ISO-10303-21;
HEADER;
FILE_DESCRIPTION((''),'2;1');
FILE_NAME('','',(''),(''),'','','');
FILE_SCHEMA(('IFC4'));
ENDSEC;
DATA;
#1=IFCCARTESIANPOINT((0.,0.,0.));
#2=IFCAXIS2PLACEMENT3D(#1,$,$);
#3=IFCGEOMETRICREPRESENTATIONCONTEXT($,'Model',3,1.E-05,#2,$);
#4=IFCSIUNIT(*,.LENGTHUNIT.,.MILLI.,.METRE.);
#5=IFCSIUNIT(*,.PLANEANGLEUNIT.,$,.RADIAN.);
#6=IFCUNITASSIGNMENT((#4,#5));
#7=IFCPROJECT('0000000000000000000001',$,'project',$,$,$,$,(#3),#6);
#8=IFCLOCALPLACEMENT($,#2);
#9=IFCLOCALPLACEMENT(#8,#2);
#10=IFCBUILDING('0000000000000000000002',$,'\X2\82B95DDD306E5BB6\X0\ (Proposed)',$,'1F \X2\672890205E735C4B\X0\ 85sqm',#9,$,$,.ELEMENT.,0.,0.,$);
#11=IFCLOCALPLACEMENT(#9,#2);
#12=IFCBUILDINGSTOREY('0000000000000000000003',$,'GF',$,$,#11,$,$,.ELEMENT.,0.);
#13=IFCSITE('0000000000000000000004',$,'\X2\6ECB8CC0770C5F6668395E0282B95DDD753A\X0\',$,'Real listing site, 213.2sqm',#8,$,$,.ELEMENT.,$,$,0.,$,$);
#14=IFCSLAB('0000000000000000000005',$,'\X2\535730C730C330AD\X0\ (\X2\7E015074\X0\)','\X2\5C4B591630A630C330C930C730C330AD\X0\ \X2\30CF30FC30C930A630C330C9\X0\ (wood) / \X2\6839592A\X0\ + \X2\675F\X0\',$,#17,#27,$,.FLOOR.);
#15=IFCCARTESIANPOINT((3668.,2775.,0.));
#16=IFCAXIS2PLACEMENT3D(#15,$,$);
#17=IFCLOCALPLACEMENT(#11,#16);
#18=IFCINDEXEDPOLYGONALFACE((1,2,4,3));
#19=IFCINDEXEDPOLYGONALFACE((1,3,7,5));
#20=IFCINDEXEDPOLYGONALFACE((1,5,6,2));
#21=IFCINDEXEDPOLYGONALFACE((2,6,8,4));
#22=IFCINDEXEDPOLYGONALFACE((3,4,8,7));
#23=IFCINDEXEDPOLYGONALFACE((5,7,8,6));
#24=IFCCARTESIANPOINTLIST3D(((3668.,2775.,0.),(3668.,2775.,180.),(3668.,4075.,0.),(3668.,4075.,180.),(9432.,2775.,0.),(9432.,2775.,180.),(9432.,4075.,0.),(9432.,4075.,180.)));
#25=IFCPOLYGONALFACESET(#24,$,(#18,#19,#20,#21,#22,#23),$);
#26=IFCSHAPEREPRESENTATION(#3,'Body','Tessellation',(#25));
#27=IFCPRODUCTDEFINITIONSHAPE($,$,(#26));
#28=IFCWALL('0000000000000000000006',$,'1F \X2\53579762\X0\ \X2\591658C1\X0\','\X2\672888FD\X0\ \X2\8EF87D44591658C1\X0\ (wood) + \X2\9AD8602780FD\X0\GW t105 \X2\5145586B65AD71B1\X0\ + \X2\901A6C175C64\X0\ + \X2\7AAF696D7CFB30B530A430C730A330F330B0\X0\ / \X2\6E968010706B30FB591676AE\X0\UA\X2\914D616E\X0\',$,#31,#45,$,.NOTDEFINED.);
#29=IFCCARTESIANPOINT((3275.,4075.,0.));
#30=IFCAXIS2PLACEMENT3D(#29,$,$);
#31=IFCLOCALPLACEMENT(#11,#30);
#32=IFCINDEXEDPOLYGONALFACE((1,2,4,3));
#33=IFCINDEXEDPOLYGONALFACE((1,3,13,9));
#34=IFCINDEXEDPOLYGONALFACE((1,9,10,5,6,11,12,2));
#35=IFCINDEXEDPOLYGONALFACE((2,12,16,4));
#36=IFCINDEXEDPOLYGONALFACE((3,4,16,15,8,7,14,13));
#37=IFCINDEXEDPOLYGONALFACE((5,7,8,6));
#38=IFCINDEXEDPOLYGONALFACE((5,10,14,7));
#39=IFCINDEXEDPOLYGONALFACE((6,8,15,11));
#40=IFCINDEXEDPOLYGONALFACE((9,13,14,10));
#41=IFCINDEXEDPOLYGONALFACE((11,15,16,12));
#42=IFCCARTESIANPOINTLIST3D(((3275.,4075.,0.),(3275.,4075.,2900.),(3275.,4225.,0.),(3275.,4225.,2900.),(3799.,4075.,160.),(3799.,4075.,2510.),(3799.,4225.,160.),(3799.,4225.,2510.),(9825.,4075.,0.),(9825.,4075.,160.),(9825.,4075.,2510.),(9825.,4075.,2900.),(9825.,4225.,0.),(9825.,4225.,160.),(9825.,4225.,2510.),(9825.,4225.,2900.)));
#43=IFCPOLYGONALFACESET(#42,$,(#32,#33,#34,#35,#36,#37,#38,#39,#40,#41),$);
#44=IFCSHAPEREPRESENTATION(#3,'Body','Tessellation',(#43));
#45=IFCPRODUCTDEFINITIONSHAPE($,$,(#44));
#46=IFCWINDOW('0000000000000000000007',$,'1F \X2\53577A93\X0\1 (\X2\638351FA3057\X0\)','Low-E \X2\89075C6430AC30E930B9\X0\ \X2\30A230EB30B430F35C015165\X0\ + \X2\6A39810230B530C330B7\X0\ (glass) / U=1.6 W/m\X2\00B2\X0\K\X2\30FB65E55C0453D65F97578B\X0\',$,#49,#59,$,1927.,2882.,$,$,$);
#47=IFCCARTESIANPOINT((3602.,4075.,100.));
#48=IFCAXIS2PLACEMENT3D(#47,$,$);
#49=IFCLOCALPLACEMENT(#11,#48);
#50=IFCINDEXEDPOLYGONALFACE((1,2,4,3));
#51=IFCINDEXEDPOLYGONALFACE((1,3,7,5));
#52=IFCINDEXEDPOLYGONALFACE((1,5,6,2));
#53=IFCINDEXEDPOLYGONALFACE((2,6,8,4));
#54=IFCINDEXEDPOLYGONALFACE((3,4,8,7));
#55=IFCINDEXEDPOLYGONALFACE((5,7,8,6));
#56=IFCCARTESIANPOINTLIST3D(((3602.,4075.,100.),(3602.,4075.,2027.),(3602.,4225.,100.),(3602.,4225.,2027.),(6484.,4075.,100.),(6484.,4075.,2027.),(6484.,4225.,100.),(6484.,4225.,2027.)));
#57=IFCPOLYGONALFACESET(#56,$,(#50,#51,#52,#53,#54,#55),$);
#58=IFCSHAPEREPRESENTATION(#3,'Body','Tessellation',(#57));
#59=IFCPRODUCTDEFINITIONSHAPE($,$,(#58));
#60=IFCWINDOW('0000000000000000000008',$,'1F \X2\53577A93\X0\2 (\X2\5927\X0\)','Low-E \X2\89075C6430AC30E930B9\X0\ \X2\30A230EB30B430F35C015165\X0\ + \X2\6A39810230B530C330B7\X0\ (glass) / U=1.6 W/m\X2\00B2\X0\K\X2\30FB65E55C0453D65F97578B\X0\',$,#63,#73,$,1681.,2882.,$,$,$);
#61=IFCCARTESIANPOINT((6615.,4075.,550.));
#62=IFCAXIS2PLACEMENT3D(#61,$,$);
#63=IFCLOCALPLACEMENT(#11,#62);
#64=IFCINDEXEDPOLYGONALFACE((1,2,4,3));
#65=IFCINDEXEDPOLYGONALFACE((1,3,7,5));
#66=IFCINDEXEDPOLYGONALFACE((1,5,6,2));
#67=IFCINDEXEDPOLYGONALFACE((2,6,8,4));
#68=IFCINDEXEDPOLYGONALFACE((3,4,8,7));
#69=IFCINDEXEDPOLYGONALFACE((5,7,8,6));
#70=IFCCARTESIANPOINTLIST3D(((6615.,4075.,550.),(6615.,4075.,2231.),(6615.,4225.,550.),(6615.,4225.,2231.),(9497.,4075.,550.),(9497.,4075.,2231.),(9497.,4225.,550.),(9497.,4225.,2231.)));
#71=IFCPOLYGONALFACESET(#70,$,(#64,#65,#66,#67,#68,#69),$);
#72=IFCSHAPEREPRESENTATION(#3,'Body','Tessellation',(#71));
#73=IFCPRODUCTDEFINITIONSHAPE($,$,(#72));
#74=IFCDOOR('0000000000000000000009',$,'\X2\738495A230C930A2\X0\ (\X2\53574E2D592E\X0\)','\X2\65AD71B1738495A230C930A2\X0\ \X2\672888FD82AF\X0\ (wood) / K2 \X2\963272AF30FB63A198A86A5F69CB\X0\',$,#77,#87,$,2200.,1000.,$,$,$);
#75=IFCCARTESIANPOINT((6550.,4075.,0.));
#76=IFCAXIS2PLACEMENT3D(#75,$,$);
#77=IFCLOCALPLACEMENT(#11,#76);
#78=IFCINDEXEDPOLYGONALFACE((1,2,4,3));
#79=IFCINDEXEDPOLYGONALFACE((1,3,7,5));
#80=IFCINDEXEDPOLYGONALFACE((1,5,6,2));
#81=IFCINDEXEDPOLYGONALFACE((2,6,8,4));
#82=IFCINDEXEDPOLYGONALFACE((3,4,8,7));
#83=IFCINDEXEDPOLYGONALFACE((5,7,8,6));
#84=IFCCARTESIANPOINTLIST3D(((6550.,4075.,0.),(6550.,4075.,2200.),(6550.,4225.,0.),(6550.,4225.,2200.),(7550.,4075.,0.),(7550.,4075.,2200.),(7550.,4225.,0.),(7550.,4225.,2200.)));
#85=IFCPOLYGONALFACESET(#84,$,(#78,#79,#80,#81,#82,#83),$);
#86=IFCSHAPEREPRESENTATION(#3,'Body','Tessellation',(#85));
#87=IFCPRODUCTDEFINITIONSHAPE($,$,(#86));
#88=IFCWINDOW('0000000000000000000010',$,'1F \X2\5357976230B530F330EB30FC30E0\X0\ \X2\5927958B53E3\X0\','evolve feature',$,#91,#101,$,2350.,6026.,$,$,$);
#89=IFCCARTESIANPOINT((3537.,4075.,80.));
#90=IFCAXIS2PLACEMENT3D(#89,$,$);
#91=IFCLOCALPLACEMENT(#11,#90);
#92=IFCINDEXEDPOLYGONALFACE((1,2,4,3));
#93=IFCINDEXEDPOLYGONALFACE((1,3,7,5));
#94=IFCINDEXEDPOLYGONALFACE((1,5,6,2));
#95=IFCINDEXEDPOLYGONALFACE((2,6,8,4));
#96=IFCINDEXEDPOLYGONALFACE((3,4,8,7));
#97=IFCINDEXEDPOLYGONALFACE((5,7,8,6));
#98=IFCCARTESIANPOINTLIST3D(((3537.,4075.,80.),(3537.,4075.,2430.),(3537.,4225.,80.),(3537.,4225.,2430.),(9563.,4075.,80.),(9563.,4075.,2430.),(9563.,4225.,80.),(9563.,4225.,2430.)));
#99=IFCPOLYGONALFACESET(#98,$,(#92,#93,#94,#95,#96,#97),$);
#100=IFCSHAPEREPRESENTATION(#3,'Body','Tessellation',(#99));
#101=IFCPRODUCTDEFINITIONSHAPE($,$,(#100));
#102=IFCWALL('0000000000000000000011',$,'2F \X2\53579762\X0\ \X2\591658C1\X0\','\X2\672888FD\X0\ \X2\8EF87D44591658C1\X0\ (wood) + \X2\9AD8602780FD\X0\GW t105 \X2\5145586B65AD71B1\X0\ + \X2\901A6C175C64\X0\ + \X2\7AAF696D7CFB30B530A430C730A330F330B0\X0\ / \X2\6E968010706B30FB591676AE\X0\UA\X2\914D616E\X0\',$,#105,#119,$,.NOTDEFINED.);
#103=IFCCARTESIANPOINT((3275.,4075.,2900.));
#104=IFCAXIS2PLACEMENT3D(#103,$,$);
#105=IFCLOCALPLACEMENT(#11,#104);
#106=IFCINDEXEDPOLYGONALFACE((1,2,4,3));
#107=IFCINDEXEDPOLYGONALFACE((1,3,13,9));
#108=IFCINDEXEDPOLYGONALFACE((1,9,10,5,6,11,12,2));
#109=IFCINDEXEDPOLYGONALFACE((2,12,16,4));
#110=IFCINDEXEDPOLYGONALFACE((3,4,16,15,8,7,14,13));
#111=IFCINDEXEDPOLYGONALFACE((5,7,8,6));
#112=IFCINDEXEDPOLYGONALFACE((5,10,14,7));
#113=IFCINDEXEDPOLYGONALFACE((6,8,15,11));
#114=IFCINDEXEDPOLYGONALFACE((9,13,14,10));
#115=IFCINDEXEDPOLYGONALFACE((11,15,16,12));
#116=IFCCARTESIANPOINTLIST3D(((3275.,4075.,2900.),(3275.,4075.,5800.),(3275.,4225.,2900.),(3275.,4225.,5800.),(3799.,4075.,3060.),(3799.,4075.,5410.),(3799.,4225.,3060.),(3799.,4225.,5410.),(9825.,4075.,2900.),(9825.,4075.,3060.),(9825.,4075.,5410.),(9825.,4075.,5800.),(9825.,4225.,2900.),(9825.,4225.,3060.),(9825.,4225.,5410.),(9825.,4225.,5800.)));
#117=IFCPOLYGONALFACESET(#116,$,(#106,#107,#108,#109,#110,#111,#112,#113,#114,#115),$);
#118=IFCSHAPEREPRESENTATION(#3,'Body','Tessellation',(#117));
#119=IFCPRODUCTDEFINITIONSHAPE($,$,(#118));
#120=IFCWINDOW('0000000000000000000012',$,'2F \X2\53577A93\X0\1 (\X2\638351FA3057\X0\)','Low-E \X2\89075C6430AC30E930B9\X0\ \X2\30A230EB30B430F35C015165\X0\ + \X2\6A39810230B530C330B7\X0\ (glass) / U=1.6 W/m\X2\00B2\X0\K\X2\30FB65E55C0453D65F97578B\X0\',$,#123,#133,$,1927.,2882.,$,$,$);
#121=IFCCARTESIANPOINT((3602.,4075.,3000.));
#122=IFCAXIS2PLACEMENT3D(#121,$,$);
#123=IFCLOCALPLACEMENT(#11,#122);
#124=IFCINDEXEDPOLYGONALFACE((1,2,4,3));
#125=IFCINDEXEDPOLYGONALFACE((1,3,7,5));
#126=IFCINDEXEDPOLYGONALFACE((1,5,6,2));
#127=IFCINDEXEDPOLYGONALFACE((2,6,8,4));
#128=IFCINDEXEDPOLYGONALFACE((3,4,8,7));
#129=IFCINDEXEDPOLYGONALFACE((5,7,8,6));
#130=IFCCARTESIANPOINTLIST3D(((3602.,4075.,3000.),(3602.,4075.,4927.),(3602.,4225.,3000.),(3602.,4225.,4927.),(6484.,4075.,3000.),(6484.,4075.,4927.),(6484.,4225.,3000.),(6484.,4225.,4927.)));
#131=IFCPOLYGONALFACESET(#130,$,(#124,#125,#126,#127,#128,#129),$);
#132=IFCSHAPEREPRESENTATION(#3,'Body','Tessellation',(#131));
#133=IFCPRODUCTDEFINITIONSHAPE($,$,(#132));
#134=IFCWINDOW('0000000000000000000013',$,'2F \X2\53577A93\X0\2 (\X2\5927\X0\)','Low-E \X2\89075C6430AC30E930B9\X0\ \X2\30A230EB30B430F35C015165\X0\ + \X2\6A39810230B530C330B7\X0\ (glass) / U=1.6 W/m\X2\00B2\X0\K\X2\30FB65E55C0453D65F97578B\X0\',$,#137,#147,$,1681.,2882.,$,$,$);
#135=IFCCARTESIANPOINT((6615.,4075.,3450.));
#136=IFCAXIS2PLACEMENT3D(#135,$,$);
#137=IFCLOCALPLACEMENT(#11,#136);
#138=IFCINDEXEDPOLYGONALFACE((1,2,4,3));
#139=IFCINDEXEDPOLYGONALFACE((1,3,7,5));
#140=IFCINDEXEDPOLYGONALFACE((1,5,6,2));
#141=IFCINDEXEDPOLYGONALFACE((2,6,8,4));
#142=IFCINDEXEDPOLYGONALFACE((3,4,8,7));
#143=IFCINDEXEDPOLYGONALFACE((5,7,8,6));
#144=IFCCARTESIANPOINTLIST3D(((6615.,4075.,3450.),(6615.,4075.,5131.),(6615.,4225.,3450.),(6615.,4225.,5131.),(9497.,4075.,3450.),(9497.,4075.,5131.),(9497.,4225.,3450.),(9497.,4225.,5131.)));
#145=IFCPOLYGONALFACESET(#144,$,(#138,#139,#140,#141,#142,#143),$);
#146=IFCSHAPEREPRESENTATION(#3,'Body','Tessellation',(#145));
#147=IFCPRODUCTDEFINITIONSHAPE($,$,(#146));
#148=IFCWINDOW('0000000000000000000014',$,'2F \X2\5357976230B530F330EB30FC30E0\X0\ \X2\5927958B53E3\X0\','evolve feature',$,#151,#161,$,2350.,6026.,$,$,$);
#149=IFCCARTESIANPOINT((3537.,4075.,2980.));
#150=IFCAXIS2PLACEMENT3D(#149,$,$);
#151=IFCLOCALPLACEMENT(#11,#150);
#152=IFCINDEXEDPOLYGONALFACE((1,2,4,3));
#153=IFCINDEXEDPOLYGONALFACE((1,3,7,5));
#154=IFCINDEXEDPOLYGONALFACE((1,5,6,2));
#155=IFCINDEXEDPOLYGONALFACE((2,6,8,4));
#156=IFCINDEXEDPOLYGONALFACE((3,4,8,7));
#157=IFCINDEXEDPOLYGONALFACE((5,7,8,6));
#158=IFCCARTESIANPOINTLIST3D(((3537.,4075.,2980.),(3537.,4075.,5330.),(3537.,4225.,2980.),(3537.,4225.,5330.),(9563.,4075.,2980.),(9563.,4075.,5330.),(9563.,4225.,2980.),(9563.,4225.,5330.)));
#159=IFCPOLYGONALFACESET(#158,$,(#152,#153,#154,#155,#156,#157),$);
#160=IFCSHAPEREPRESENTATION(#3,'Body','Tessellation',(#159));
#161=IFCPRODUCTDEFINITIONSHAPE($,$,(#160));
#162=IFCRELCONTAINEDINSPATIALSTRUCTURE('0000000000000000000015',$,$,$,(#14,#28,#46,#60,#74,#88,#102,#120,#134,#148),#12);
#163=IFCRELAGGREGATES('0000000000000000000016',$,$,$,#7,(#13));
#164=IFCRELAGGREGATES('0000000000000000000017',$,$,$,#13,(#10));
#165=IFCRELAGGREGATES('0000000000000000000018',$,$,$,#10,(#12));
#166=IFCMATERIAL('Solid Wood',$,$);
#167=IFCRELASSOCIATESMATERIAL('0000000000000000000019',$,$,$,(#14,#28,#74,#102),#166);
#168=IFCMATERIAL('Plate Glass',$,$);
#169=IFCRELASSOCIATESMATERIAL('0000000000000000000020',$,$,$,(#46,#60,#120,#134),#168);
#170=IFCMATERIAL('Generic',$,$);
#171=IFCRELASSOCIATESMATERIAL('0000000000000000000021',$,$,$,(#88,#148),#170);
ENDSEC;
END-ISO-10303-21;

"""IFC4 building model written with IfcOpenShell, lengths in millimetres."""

from ifc_helpers import new_model, si_unit, frame, frame_2d, origin, place, context, project, spatial, rectangle, extrude, material, element, fill, save


model = new_model("IFC4")

# Units and contexts
model_context = context("Model", 3, precision=1e-05, world=origin())
ifc_project = project(units=[si_unit("LENGTHUNIT", "METRE", prefix="MILLI"), si_unit("PLANEANGLEUNIT", "RADIAN")], contexts=[model_context])

# Site, building, storey
site_placement = place(None, origin())
site = spatial("IfcSite", under=ifc_project, at=site_placement, Name="滋賀県彦根市芹川町", ObjectType="Real listing site, 213.2sqm", CompositionType="ELEMENT", RefElevation=0.0)
building_placement = place(site_placement, origin())
building = spatial("IfcBuilding", under=site, at=building_placement, Name="芹川の家 (Proposed)", ObjectType="1F 木造平屋 85sqm", CompositionType="ELEMENT", ElevationOfRefHeight=0.0, ElevationOfTerrain=0.0)
storey_placement = place(building_placement, origin())
storey = spatial("IfcBuildingStorey", under=building, at=storey_placement, Name="GF", CompositionType="ELEMENT", Elevation=0.0)

# Slab
ifc_material_1 = material(Name="Solid Wood")
slab_1_placement = place(storey_placement, frame((3668.0, 2775.0, 0.0)))
element("IfcSlab", 1, at=slab_1_placement, inside=storey, material=ifc_material_1, Name="南デッキ (縁側)", Description="屋外ウッドデッキ ハードウッド (wood) / 根太 + 束", PredefinedType="FLOOR", context=model_context, shape_type="SweptSolid", body=[
    extrude(rectangle(XDim=5764.0, YDim=1300.0, at=frame_2d((2882.0, 650.0))), frame((3668.0, 2775.0, 0.0)), (0.0, 0.0, 1.0), 180.0),
])
ifc_material_2 = material(Name="Generic")

# Wall, openings, windows, door
wall_1_placement = place(storey_placement, frame((3275.0, 4075.0, 0.0)))
wall_1 = element("IfcWall", 2, at=wall_1_placement, inside=storey, material=ifc_material_1, Name="1F 南面 外壁", Description="木製 軸組外壁 (wood) + 高性能GW t105 充填断熱 + 通気層 + 窯業系サイディング / 準耐火・外皮UA配慮", PredefinedType="NOTDEFINED", context=model_context, shape_type="SweptSolid", body=[
    extrude(rectangle(XDim=6550.0, YDim=150.0, at=frame_2d((3275.0, 75.0))), frame((3275.0, 4075.0, 0.0)), (0.0, 0.0, 1.0), 2900.0),
])
opening_1_placement = place(storey_placement, frame((3602.0, 4075.0, 100.0)))
opening_1 = element("IfcOpeningElement", 3, at=opening_1_placement, cuts=wall_1, PredefinedType="NOTDEFINED", context=model_context, shape_type="SweptSolid", body=[
    extrude(rectangle(XDim=2882.0, YDim=150.0, at=frame_2d((1441.0, 75.0))), frame((3602.0, 4075.0, 100.0)), (0.0, 0.0, 1.0), 1927.0),
])
opening_2_placement = place(storey_placement, frame((6615.0, 4075.0, 550.0)))
opening_2 = element("IfcOpeningElement", 4, at=opening_2_placement, cuts=wall_1, PredefinedType="NOTDEFINED", context=model_context, shape_type="SweptSolid", body=[
    extrude(rectangle(XDim=2882.0, YDim=150.0, at=frame_2d((1441.0, 75.0))), frame((6615.0, 4075.0, 550.0)), (0.0, 0.0, 1.0), 1681.0),
])
opening_3_placement = place(storey_placement, frame((6550.0, 4075.0, 0.0)))
opening_3 = element("IfcOpeningElement", 5, at=opening_3_placement, cuts=wall_1, PredefinedType="NOTDEFINED", context=model_context, shape_type="SweptSolid", body=[
    extrude(rectangle(XDim=1000.0, YDim=150.0, at=frame_2d((500.0, 75.0))), frame((6550.0, 4075.0, 0.0)), (0.0, 0.0, 1.0), 2200.0),
])
opening_4_placement = place(storey_placement, frame((3537.0, 4075.0, 80.0)))
opening_4 = element("IfcOpeningElement", 6, at=opening_4_placement, cuts=wall_1, PredefinedType="NOTDEFINED", context=model_context, shape_type="SweptSolid", body=[
    extrude(rectangle(XDim=6026.0, YDim=150.0, at=frame_2d((3013.0, 75.0))), frame((3537.0, 4075.0, 80.0)), (0.0, 0.0, 1.0), 2350.0),
])
ifc_material_3 = material(Name="Plate Glass")
window_1_placement = place(storey_placement, frame((3602.0, 4075.0, 100.0)))
window_1 = element("IfcWindow", 7, at=window_1_placement, inside=storey, material=ifc_material_3, Name="1F 南窓1 (掃出し)", Description="Low-E 複層ガラス アルゴン封入 + 樹脂サッシ (glass) / U=1.6 W/m²K・日射取得型", OverallHeight=1927.0, OverallWidth=2882.0, context=model_context, shape_type="SweptSolid", body=[
    extrude(rectangle(XDim=2882.0, YDim=150.0, at=frame_2d((1441.0, 75.0))), frame((3602.0, 4075.0, 100.0)), (0.0, 0.0, 1.0), 1927.0),
])
fill(opening_1, window_1)
window_2_placement = place(storey_placement, frame((6615.0, 4075.0, 550.0)))
window_2 = element("IfcWindow", 8, at=window_2_placement, inside=storey, material=ifc_material_3, Name="1F 南窓2 (大)", Description="Low-E 複層ガラス アルゴン封入 + 樹脂サッシ (glass) / U=1.6 W/m²K・日射取得型", OverallHeight=1681.0, OverallWidth=2882.0, context=model_context, shape_type="SweptSolid", body=[
    extrude(rectangle(XDim=2882.0, YDim=150.0, at=frame_2d((1441.0, 75.0))), frame((6615.0, 4075.0, 550.0)), (0.0, 0.0, 1.0), 1681.0),
])
fill(opening_2, window_2)
door_placement = place(storey_placement, frame((6550.0, 4075.0, 0.0)))
door = element("IfcDoor", 9, at=door_placement, inside=storey, material=ifc_material_1, Name="玄関ドア (南中央)", Description="断熱玄関ドア 木製芯 (wood) / K2 防犯・採風機構", OverallHeight=2200.0, OverallWidth=1000.0, context=model_context, shape_type="SweptSolid", body=[
    extrude(rectangle(XDim=1000.0, YDim=150.0, at=frame_2d((500.0, 75.0))), frame((6550.0, 4075.0, 0.0)), (0.0, 0.0, 1.0), 2200.0),
])
fill(opening_3, door)
window_3_placement = place(storey_placement, frame((3537.0, 4075.0, 80.0)))
window_3 = element("IfcWindow", 10, at=window_3_placement, inside=storey, material=ifc_material_2, Name="1F 南面サンルーム 大開口", Description="evolve feature", OverallHeight=2350.0, OverallWidth=6026.0, context=model_context, shape_type="SweptSolid", body=[
    extrude(rectangle(XDim=6026.0, YDim=150.0, at=frame_2d((3013.0, 75.0))), frame((3537.0, 4075.0, 80.0)), (0.0, 0.0, 1.0), 2350.0),
])
fill(opening_4, window_3)

# Wall, openings, windows
wall_2_placement = place(storey_placement, frame((3275.0, 4075.0, 2900.0)))
wall_2 = element("IfcWall", 11, at=wall_2_placement, inside=storey, material=ifc_material_1, Name="2F 南面 外壁", Description="木製 軸組外壁 (wood) + 高性能GW t105 充填断熱 + 通気層 + 窯業系サイディング / 準耐火・外皮UA配慮", PredefinedType="NOTDEFINED", context=model_context, shape_type="SweptSolid", body=[
    extrude(rectangle(XDim=6550.0, YDim=150.0, at=frame_2d((3275.0, 75.0))), frame((3275.0, 4075.0, 2900.0)), (0.0, 0.0, 1.0), 2900.0),
])
opening_5_placement = place(storey_placement, frame((3602.0, 4075.0, 3000.0)))
opening_5 = element("IfcOpeningElement", 12, at=opening_5_placement, cuts=wall_2, PredefinedType="NOTDEFINED", context=model_context, shape_type="SweptSolid", body=[
    extrude(rectangle(XDim=2882.0, YDim=150.0, at=frame_2d((1441.0, 75.0))), frame((3602.0, 4075.0, 3000.0)), (0.0, 0.0, 1.0), 1927.0),
])
opening_6_placement = place(storey_placement, frame((6615.0, 4075.0, 3450.0)))
opening_6 = element("IfcOpeningElement", 13, at=opening_6_placement, cuts=wall_2, PredefinedType="NOTDEFINED", context=model_context, shape_type="SweptSolid", body=[
    extrude(rectangle(XDim=2882.0, YDim=150.0, at=frame_2d((1441.0, 75.0))), frame((6615.0, 4075.0, 3450.0)), (0.0, 0.0, 1.0), 1681.0),
])
opening_7_placement = place(storey_placement, frame((3537.0, 4075.0, 2980.0)))
opening_7 = element("IfcOpeningElement", 14, at=opening_7_placement, cuts=wall_2, PredefinedType="NOTDEFINED", context=model_context, shape_type="SweptSolid", body=[
    extrude(rectangle(XDim=6026.0, YDim=150.0, at=frame_2d((3013.0, 75.0))), frame((3537.0, 4075.0, 2980.0)), (0.0, 0.0, 1.0), 2350.0),
])
window_4_placement = place(storey_placement, frame((3602.0, 4075.0, 3000.0)))
window_4 = element("IfcWindow", 15, at=window_4_placement, inside=storey, material=ifc_material_3, Name="2F 南窓1 (掃出し)", Description="Low-E 複層ガラス アルゴン封入 + 樹脂サッシ (glass) / U=1.6 W/m²K・日射取得型", OverallHeight=1927.0, OverallWidth=2882.0, context=model_context, shape_type="SweptSolid", body=[
    extrude(rectangle(XDim=2882.0, YDim=150.0, at=frame_2d((1441.0, 75.0))), frame((3602.0, 4075.0, 3000.0)), (0.0, 0.0, 1.0), 1927.0),
])
fill(opening_5, window_4)
window_5_placement = place(storey_placement, frame((6615.0, 4075.0, 3450.0)))
window_5 = element("IfcWindow", 16, at=window_5_placement, inside=storey, material=ifc_material_3, Name="2F 南窓2 (大)", Description="Low-E 複層ガラス アルゴン封入 + 樹脂サッシ (glass) / U=1.6 W/m²K・日射取得型", OverallHeight=1681.0, OverallWidth=2882.0, context=model_context, shape_type="SweptSolid", body=[
    extrude(rectangle(XDim=2882.0, YDim=150.0, at=frame_2d((1441.0, 75.0))), frame((6615.0, 4075.0, 3450.0)), (0.0, 0.0, 1.0), 1681.0),
])
fill(opening_6, window_5)
window_6_placement = place(storey_placement, frame((3537.0, 4075.0, 2980.0)))
window_6 = element("IfcWindow", 17, at=window_6_placement, inside=storey, material=ifc_material_2, Name="2F 南面サンルーム 大開口", Description="evolve feature", OverallHeight=2350.0, OverallWidth=6026.0, context=model_context, shape_type="SweptSolid", body=[
    extrude(rectangle(XDim=6026.0, YDim=150.0, at=frame_2d((3013.0, 75.0))), frame((3537.0, 4075.0, 2980.0)), (0.0, 0.0, 1.0), 2350.0),
])
fill(opening_7, window_6)

save(model, "model.ifc")
